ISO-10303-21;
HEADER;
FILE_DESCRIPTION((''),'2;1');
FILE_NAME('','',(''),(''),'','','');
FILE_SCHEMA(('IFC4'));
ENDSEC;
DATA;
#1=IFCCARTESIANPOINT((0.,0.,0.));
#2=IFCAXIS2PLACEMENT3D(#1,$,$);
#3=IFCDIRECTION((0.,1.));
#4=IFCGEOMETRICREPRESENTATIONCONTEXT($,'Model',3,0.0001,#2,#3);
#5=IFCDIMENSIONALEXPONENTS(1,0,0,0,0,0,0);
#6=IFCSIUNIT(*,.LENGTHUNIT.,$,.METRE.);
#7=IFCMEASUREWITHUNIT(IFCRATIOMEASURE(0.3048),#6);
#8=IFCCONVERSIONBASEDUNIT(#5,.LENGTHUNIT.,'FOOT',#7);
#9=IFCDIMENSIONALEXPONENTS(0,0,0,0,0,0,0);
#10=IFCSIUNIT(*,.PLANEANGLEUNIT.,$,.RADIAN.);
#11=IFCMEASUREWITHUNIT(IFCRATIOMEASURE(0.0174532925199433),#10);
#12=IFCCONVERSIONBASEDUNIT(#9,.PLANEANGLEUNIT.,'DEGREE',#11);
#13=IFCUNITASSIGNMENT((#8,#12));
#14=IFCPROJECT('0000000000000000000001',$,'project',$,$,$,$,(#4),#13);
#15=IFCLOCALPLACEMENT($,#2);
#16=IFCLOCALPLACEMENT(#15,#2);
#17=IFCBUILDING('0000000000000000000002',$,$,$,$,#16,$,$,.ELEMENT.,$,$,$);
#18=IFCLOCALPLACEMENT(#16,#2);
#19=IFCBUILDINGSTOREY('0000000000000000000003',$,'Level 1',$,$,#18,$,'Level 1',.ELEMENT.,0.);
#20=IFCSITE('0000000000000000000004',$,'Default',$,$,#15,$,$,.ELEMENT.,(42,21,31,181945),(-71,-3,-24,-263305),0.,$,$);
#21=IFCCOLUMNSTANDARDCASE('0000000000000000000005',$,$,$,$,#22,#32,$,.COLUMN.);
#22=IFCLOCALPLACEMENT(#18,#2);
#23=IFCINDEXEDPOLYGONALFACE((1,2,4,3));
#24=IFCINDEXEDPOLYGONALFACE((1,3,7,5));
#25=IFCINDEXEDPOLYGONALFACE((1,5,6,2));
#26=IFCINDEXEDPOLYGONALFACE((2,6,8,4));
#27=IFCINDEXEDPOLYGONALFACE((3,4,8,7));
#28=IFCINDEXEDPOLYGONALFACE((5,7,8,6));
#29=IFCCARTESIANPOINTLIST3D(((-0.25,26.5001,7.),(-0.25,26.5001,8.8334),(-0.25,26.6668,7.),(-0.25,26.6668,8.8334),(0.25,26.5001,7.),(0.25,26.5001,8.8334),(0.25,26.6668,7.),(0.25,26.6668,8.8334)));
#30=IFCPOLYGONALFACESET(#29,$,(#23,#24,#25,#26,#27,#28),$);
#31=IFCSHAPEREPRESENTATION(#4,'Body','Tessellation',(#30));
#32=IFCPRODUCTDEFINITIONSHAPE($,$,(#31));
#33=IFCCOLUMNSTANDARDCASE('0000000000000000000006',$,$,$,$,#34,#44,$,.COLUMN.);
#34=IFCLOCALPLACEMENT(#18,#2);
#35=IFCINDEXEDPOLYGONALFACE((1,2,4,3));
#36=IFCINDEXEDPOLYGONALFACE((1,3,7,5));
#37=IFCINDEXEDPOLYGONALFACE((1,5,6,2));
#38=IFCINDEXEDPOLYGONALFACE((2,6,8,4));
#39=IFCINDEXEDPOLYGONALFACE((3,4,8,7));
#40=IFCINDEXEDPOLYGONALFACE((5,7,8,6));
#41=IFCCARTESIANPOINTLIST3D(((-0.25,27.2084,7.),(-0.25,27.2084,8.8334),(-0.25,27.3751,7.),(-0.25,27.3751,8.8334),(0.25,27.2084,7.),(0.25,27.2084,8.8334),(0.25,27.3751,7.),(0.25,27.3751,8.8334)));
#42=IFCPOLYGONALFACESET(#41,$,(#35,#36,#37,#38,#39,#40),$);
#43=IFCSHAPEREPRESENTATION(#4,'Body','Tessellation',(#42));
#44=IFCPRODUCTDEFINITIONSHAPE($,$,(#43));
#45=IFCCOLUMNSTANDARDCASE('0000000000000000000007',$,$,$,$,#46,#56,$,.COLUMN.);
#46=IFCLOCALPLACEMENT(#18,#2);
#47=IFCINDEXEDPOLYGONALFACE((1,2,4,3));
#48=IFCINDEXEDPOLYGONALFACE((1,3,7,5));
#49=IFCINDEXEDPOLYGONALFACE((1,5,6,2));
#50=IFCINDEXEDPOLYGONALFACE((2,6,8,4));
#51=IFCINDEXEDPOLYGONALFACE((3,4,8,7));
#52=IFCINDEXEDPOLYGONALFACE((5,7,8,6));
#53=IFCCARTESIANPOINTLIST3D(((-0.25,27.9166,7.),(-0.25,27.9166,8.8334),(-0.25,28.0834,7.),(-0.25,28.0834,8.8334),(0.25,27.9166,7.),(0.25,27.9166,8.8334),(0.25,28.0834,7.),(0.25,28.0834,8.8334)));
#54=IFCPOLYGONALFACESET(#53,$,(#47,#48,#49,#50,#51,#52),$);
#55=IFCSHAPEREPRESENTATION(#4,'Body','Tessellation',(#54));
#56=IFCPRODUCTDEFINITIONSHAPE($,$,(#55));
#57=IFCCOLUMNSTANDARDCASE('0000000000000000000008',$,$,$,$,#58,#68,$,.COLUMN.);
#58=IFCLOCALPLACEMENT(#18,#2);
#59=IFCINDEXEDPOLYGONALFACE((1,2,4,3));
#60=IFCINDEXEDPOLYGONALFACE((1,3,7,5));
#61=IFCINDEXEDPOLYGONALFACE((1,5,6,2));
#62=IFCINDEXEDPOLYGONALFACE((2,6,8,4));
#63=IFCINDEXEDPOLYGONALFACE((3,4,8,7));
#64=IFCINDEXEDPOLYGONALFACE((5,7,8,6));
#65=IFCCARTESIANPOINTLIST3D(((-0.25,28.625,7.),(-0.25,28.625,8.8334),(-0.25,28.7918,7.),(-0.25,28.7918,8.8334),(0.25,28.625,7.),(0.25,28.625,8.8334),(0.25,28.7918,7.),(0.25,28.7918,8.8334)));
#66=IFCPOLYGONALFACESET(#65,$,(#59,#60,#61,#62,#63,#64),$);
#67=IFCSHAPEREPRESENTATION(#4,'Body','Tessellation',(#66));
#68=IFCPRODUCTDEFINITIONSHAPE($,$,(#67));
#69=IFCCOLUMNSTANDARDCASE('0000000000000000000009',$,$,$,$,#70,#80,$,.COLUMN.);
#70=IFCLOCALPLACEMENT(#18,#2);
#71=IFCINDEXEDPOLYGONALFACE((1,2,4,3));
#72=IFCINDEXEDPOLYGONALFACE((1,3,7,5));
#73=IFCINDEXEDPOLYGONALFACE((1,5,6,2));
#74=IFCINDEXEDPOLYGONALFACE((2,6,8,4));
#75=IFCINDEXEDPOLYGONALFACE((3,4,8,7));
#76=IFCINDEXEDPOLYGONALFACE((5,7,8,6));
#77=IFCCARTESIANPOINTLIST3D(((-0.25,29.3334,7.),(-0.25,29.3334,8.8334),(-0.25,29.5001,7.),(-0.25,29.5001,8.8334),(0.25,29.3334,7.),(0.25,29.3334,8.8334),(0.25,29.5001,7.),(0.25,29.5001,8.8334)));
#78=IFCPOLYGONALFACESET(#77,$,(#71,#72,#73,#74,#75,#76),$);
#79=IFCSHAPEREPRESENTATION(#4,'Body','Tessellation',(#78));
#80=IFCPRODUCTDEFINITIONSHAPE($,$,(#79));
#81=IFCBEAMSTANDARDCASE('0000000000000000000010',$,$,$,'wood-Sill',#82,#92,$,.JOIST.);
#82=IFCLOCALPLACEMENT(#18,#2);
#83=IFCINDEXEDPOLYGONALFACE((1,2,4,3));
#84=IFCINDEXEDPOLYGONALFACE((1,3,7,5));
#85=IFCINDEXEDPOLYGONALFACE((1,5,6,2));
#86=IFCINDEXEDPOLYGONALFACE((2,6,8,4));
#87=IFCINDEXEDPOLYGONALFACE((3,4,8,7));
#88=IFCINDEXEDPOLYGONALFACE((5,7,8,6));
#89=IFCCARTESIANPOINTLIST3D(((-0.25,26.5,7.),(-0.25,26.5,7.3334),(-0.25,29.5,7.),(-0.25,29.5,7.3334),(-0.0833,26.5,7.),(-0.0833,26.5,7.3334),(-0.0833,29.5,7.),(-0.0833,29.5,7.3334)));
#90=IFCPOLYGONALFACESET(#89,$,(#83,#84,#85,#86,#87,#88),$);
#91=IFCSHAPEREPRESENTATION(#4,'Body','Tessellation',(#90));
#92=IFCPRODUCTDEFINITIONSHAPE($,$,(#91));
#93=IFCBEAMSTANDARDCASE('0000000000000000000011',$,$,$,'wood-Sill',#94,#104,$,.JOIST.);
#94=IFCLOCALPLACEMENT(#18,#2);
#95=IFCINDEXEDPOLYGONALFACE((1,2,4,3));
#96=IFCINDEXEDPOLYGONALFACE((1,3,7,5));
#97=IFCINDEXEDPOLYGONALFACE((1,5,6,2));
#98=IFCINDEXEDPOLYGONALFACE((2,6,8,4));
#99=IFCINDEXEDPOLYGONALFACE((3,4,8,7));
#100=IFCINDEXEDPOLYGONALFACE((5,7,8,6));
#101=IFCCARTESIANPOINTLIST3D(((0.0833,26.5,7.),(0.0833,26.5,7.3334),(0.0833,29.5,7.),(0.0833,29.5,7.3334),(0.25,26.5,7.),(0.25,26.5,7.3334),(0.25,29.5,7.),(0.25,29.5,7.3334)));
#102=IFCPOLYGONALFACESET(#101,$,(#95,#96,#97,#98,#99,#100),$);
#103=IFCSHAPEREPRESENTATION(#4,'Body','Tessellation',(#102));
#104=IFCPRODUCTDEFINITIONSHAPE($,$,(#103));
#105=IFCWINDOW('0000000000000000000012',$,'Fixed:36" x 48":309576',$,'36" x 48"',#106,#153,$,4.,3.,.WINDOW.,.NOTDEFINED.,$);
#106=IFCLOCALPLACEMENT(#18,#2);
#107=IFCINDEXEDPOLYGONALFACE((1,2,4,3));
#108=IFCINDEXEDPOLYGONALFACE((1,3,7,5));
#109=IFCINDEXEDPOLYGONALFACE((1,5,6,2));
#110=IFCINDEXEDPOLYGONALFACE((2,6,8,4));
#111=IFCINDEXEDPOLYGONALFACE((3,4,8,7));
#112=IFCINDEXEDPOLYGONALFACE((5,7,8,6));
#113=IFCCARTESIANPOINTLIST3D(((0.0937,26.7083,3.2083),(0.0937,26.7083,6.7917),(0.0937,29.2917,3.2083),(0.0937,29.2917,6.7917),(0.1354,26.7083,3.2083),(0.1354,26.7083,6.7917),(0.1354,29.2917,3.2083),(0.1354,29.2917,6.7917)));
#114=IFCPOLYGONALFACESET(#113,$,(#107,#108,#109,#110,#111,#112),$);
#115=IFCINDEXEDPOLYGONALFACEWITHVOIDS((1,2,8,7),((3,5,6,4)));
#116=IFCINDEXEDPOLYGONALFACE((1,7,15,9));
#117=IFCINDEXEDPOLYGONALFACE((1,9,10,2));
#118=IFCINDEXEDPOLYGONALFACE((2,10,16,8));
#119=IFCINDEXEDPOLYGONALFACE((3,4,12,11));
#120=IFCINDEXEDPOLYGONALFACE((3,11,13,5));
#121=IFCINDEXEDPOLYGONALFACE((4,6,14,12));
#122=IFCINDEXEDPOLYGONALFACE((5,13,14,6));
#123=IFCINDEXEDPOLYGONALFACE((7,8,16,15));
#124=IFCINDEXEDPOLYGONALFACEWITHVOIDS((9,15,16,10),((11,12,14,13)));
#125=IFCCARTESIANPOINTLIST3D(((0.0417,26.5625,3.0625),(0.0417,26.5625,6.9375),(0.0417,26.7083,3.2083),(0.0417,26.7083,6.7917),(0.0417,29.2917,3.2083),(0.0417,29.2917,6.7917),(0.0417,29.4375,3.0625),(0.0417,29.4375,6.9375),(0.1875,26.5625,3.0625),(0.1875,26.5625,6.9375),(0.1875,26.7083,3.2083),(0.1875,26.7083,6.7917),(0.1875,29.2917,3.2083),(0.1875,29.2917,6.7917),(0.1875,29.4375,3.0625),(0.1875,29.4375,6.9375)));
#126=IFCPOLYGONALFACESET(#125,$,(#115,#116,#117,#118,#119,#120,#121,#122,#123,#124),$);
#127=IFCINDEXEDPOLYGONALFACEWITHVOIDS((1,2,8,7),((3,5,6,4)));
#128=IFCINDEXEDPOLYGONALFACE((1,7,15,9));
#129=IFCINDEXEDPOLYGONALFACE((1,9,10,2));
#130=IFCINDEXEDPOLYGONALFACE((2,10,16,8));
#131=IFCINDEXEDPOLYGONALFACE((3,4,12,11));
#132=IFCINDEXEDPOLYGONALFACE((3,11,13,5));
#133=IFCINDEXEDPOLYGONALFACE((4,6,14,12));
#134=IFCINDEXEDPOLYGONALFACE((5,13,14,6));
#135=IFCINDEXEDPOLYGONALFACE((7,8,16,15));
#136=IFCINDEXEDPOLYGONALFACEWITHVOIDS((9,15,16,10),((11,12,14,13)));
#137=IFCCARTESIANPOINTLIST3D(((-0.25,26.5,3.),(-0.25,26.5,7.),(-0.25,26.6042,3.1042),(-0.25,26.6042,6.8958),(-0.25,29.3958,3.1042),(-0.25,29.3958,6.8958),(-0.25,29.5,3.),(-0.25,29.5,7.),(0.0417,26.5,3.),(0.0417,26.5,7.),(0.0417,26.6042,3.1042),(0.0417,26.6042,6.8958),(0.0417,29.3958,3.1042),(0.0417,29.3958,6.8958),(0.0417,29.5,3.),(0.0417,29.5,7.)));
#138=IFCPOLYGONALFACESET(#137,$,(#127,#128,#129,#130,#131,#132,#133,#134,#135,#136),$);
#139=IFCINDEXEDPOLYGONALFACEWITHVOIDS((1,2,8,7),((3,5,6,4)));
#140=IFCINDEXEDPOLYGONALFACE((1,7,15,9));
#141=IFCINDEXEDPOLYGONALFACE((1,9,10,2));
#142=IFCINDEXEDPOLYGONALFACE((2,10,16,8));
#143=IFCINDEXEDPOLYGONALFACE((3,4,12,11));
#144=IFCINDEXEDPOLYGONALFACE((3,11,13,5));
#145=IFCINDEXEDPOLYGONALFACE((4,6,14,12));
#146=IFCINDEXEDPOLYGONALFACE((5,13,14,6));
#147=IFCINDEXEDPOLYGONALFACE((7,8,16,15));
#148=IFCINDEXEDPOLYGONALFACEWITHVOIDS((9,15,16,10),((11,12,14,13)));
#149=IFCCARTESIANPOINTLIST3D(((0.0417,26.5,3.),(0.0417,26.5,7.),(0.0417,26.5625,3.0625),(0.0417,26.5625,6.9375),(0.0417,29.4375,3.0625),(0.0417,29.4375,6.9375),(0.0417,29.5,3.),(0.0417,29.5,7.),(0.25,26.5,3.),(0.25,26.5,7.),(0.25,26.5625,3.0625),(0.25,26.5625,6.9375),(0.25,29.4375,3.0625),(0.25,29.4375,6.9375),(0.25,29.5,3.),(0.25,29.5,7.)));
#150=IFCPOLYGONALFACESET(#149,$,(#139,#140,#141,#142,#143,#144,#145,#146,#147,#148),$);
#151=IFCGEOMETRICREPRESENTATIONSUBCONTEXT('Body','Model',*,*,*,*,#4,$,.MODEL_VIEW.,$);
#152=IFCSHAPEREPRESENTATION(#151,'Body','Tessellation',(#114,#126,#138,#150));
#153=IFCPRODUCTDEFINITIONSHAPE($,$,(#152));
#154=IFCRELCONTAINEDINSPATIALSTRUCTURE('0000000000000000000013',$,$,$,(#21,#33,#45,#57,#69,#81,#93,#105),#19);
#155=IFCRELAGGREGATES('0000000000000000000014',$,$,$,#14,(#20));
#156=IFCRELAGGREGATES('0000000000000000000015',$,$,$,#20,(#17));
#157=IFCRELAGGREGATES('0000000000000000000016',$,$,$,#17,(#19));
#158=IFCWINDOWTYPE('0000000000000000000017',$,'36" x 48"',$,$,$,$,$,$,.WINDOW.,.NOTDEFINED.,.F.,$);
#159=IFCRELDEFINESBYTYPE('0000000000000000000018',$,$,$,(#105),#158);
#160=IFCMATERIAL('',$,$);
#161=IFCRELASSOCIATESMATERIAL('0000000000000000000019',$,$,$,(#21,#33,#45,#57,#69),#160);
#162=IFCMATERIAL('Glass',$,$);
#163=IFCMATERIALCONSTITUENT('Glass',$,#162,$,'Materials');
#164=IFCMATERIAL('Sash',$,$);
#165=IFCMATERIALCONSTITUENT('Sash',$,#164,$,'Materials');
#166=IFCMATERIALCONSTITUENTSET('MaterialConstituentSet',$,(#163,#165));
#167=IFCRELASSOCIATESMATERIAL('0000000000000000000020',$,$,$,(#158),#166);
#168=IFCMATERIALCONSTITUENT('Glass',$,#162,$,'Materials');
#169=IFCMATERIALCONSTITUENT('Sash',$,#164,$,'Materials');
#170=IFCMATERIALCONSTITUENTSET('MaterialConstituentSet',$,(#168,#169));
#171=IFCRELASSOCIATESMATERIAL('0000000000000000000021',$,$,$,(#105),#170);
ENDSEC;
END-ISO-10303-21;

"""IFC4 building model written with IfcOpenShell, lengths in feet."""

from ifc_helpers import new_model, entity, si_unit, converted_unit, direction, frame, frame_2d, origin, origin_with_axes, place, context, subcontext, project, spatial, polyline, rectangle, outline, extrude, source, transform, mapped, material, constituent, constituent_set, type_object, type_shapes, element, save


model = new_model("IFC4")

# Units and contexts
model_context = context("Model", 3, precision=0.0001, world=origin(), true_north=direction((0.0, 1.0)))
body_context = subcontext(model_context, "Body", "Model", "MODEL_VIEW")
ifc_project = project(units=[converted_unit("LENGTHUNIT", "FOOT", entity("IfcRatioMeasure", 0.3048), si_unit("LENGTHUNIT", "METRE"), dimensions=[1, 0, 0, 0, 0, 0, 0]), converted_unit("PLANEANGLEUNIT", "DEGREE", entity("IfcRatioMeasure", 0.0174532925199433), si_unit("PLANEANGLEUNIT", "RADIAN"), dimensions=[0, 0, 0, 0, 0, 0, 0])], contexts=[model_context])

# Site, building, storey
site_placement = place(None, origin())
site = spatial("IfcSite", under=ifc_project, at=site_placement, Name="Default", CompositionType="ELEMENT", RefLatitude=(42, 21, 31, 181945), RefLongitude=(-71, -3, -24, -263305), RefElevation=0.0)
building_placement = place(site_placement, origin())
building = spatial("IfcBuilding", under=site, at=building_placement, CompositionType="ELEMENT")
storey_placement = place(building_placement, origin())
storey = spatial("IfcBuildingStorey", under=building, at=storey_placement, Name="Level 1", LongName="Level 1", CompositionType="ELEMENT", Elevation=0.0)

# Columns
placement_1 = place(storey_placement, frame((0.0, -0.25, 0.0), z_axis=(0.0, 0.0, 1.0), x_axis=(0.0, 1.0, 0.0)))
ifc_material_1 = material(Name="")
for number, where, z_axis, x_axis in (
    (1, (26.8334, 0.0, 7.0), (0.0, 0.0, 1.0), (1.0, 0.0, 0.0)),
    (2, (27.5417, 0.0, 7.0), (0.0, 0.0, 1.0), (1.0, 0.0, 0.0)),
    (3, (28.25, 0.0, 7.0), (0.0, 0.0, 1.0), (1.0, 0.0, 0.0)),
    (4, (28.9584, 0.0, 7.0), (0.0, 0.0, 1.0), (1.0, 0.0, 0.0)),
    (5, (29.6667, 0.0, 7.0), (0.0, 0.0, 1.0), (1.0, 0.0, 0.0)),
):
    element("IfcColumnStandardCase", number, at=place(placement_1, frame(where, z_axis=z_axis, x_axis=x_axis)), inside=storey, material=ifc_material_1, PredefinedType="COLUMN", context=model_context, shape_type="SweptSolid", body=[
        extrude(rectangle(XDim=0.1667, YDim=0.5), origin(), (0.0, 0.0, 1.0), 1.8334),
    ])

# Beams
for number, where, z_axis, x_axis in (
    (6, (26.75, 0.1667, 7.1667), (1.0, 0.0, 0.0), (0.0, 0.0, 1.0)),
    (7, (26.75, -0.1667, 7.1667), (1.0, 0.0, 0.0), (0.0, 0.0, 1.0)),
):
    element("IfcBeamStandardCase", number, at=place(placement_1, frame(where, z_axis=z_axis, x_axis=x_axis)), inside=storey, ObjectType="wood-Sill", PredefinedType="JOIST", context=model_context, shape_type="SweptSolid", body=[
        extrude(rectangle(XDim=0.3333, YDim=0.1667), origin_with_axes(), (0.0, 0.0, 1.0), 3.0),
    ])

# Window
ifc_material_2 = material(Name="Glass")
ifc_constituent_1 = constituent(ifc_material_2, Name="Glass", Category="Materials")
ifc_material_3 = material(Name="Sash")
ifc_constituent_2 = constituent(ifc_material_3, Name="Sash", Category="Materials")
ifc_constituent_set_1 = constituent_set(constituents=[ifc_constituent_1, ifc_constituent_2], Name="MaterialConstituentSet")
ifc_constituent_3 = constituent(ifc_material_2, Name="Glass", Category="Materials")
ifc_constituent_4 = constituent(ifc_material_3, Name="Sash", Category="Materials")
ifc_constituent_set_2 = constituent_set(constituents=[ifc_constituent_3, ifc_constituent_4], Name="MaterialConstituentSet")
window_type = type_object("IfcWindowType", Name="36\" x 48\"", ParameterTakesPrecedence=False, PartitioningType="NOTDEFINED", PredefinedType="WINDOW", material=ifc_constituent_set_2)
shared_shape = source(origin(), body_context, "Body", "SweptSolid", [
    extrude(rectangle(XDim=0.0417, YDim=2.5833, at=frame_2d((0.0, 0.0), x_axis=(1.0, 0.0))), frame((1.5, 0.3646, 0.2083), z_axis=(0.0, 0.0, 1.0), x_axis=(0.0, 1.0, 0.0)), (0.0, 0.0, 1.0), 3.5833),
    extrude(outline(polyline([(-1.4375, -1.9375), (1.4375, -1.9375), (1.4375, 1.9375), (-1.4375, 1.9375), (-1.4375, -1.9375)]), holes=[polyline([(-1.2917, -1.7917), (-1.2917, 1.7917), (1.2917, 1.7917), (1.2917, -1.7917), (-1.2917, -1.7917)])]), frame((1.5, 0.2917, 2.0), z_axis=(0.0, 1.0, 0.0), x_axis=(1.0, 0.0, 0.0)), (0.0, 0.0, 1.0), 0.1458),
    extrude(outline(polyline([(-1.5, -2.0), (1.5, -2.0), (1.5, 2.0), (-1.5, 2.0), (-1.5, -2.0)]), holes=[polyline([(-1.3958, -1.8958), (-1.3958, 1.8958), (1.3958, 1.8958), (1.3958, -1.8958), (-1.3958, -1.8958)])]), frame((1.5, 0.0, 2.0), z_axis=(0.0, 1.0, 0.0), x_axis=(1.0, 0.0, 0.0)), (0.0, 0.0, 1.0), 0.2917),
    extrude(outline(polyline([(-2.0, -1.5), (2.0, -1.5), (2.0, 1.5), (-2.0, 1.5), (-2.0, -1.5)]), holes=[polyline([(-1.9375, -1.4375), (-1.9375, 1.4375), (1.9375, 1.4375), (1.9375, -1.4375), (-1.9375, -1.4375)])]), frame((1.5, 0.2917, 2.0), z_axis=(0.0, 1.0, 0.0), x_axis=(0.0, 0.0, -1.0)), (0.0, 0.0, 1.0), 0.2083),
])
type_shapes(window_type, [shared_shape])
placement_2 = place(placement_1, frame((29.75, 0.25, 3.0)))
window_placement = place(placement_2, frame((0.0, 0.0, 0.0), z_axis=(0.0, 0.0, 1.0), x_axis=(-1.0, 0.0, 0.0)))
element("IfcWindow", 8, at=window_placement, inside=storey, type_object=window_type, material=ifc_constituent_set_1, Name="Fixed:36\" x 48\":309576", ObjectType="36\" x 48\"", OverallHeight=4.0, OverallWidth=3.0, PartitioningType="NOTDEFINED", PredefinedType="WINDOW", context=body_context, shape_type="MappedRepresentation", body=[
    mapped(shared_shape, transform((0.0, 0.0, 0.0), scale=1.0)),
])

save(model, "model.ifc")
